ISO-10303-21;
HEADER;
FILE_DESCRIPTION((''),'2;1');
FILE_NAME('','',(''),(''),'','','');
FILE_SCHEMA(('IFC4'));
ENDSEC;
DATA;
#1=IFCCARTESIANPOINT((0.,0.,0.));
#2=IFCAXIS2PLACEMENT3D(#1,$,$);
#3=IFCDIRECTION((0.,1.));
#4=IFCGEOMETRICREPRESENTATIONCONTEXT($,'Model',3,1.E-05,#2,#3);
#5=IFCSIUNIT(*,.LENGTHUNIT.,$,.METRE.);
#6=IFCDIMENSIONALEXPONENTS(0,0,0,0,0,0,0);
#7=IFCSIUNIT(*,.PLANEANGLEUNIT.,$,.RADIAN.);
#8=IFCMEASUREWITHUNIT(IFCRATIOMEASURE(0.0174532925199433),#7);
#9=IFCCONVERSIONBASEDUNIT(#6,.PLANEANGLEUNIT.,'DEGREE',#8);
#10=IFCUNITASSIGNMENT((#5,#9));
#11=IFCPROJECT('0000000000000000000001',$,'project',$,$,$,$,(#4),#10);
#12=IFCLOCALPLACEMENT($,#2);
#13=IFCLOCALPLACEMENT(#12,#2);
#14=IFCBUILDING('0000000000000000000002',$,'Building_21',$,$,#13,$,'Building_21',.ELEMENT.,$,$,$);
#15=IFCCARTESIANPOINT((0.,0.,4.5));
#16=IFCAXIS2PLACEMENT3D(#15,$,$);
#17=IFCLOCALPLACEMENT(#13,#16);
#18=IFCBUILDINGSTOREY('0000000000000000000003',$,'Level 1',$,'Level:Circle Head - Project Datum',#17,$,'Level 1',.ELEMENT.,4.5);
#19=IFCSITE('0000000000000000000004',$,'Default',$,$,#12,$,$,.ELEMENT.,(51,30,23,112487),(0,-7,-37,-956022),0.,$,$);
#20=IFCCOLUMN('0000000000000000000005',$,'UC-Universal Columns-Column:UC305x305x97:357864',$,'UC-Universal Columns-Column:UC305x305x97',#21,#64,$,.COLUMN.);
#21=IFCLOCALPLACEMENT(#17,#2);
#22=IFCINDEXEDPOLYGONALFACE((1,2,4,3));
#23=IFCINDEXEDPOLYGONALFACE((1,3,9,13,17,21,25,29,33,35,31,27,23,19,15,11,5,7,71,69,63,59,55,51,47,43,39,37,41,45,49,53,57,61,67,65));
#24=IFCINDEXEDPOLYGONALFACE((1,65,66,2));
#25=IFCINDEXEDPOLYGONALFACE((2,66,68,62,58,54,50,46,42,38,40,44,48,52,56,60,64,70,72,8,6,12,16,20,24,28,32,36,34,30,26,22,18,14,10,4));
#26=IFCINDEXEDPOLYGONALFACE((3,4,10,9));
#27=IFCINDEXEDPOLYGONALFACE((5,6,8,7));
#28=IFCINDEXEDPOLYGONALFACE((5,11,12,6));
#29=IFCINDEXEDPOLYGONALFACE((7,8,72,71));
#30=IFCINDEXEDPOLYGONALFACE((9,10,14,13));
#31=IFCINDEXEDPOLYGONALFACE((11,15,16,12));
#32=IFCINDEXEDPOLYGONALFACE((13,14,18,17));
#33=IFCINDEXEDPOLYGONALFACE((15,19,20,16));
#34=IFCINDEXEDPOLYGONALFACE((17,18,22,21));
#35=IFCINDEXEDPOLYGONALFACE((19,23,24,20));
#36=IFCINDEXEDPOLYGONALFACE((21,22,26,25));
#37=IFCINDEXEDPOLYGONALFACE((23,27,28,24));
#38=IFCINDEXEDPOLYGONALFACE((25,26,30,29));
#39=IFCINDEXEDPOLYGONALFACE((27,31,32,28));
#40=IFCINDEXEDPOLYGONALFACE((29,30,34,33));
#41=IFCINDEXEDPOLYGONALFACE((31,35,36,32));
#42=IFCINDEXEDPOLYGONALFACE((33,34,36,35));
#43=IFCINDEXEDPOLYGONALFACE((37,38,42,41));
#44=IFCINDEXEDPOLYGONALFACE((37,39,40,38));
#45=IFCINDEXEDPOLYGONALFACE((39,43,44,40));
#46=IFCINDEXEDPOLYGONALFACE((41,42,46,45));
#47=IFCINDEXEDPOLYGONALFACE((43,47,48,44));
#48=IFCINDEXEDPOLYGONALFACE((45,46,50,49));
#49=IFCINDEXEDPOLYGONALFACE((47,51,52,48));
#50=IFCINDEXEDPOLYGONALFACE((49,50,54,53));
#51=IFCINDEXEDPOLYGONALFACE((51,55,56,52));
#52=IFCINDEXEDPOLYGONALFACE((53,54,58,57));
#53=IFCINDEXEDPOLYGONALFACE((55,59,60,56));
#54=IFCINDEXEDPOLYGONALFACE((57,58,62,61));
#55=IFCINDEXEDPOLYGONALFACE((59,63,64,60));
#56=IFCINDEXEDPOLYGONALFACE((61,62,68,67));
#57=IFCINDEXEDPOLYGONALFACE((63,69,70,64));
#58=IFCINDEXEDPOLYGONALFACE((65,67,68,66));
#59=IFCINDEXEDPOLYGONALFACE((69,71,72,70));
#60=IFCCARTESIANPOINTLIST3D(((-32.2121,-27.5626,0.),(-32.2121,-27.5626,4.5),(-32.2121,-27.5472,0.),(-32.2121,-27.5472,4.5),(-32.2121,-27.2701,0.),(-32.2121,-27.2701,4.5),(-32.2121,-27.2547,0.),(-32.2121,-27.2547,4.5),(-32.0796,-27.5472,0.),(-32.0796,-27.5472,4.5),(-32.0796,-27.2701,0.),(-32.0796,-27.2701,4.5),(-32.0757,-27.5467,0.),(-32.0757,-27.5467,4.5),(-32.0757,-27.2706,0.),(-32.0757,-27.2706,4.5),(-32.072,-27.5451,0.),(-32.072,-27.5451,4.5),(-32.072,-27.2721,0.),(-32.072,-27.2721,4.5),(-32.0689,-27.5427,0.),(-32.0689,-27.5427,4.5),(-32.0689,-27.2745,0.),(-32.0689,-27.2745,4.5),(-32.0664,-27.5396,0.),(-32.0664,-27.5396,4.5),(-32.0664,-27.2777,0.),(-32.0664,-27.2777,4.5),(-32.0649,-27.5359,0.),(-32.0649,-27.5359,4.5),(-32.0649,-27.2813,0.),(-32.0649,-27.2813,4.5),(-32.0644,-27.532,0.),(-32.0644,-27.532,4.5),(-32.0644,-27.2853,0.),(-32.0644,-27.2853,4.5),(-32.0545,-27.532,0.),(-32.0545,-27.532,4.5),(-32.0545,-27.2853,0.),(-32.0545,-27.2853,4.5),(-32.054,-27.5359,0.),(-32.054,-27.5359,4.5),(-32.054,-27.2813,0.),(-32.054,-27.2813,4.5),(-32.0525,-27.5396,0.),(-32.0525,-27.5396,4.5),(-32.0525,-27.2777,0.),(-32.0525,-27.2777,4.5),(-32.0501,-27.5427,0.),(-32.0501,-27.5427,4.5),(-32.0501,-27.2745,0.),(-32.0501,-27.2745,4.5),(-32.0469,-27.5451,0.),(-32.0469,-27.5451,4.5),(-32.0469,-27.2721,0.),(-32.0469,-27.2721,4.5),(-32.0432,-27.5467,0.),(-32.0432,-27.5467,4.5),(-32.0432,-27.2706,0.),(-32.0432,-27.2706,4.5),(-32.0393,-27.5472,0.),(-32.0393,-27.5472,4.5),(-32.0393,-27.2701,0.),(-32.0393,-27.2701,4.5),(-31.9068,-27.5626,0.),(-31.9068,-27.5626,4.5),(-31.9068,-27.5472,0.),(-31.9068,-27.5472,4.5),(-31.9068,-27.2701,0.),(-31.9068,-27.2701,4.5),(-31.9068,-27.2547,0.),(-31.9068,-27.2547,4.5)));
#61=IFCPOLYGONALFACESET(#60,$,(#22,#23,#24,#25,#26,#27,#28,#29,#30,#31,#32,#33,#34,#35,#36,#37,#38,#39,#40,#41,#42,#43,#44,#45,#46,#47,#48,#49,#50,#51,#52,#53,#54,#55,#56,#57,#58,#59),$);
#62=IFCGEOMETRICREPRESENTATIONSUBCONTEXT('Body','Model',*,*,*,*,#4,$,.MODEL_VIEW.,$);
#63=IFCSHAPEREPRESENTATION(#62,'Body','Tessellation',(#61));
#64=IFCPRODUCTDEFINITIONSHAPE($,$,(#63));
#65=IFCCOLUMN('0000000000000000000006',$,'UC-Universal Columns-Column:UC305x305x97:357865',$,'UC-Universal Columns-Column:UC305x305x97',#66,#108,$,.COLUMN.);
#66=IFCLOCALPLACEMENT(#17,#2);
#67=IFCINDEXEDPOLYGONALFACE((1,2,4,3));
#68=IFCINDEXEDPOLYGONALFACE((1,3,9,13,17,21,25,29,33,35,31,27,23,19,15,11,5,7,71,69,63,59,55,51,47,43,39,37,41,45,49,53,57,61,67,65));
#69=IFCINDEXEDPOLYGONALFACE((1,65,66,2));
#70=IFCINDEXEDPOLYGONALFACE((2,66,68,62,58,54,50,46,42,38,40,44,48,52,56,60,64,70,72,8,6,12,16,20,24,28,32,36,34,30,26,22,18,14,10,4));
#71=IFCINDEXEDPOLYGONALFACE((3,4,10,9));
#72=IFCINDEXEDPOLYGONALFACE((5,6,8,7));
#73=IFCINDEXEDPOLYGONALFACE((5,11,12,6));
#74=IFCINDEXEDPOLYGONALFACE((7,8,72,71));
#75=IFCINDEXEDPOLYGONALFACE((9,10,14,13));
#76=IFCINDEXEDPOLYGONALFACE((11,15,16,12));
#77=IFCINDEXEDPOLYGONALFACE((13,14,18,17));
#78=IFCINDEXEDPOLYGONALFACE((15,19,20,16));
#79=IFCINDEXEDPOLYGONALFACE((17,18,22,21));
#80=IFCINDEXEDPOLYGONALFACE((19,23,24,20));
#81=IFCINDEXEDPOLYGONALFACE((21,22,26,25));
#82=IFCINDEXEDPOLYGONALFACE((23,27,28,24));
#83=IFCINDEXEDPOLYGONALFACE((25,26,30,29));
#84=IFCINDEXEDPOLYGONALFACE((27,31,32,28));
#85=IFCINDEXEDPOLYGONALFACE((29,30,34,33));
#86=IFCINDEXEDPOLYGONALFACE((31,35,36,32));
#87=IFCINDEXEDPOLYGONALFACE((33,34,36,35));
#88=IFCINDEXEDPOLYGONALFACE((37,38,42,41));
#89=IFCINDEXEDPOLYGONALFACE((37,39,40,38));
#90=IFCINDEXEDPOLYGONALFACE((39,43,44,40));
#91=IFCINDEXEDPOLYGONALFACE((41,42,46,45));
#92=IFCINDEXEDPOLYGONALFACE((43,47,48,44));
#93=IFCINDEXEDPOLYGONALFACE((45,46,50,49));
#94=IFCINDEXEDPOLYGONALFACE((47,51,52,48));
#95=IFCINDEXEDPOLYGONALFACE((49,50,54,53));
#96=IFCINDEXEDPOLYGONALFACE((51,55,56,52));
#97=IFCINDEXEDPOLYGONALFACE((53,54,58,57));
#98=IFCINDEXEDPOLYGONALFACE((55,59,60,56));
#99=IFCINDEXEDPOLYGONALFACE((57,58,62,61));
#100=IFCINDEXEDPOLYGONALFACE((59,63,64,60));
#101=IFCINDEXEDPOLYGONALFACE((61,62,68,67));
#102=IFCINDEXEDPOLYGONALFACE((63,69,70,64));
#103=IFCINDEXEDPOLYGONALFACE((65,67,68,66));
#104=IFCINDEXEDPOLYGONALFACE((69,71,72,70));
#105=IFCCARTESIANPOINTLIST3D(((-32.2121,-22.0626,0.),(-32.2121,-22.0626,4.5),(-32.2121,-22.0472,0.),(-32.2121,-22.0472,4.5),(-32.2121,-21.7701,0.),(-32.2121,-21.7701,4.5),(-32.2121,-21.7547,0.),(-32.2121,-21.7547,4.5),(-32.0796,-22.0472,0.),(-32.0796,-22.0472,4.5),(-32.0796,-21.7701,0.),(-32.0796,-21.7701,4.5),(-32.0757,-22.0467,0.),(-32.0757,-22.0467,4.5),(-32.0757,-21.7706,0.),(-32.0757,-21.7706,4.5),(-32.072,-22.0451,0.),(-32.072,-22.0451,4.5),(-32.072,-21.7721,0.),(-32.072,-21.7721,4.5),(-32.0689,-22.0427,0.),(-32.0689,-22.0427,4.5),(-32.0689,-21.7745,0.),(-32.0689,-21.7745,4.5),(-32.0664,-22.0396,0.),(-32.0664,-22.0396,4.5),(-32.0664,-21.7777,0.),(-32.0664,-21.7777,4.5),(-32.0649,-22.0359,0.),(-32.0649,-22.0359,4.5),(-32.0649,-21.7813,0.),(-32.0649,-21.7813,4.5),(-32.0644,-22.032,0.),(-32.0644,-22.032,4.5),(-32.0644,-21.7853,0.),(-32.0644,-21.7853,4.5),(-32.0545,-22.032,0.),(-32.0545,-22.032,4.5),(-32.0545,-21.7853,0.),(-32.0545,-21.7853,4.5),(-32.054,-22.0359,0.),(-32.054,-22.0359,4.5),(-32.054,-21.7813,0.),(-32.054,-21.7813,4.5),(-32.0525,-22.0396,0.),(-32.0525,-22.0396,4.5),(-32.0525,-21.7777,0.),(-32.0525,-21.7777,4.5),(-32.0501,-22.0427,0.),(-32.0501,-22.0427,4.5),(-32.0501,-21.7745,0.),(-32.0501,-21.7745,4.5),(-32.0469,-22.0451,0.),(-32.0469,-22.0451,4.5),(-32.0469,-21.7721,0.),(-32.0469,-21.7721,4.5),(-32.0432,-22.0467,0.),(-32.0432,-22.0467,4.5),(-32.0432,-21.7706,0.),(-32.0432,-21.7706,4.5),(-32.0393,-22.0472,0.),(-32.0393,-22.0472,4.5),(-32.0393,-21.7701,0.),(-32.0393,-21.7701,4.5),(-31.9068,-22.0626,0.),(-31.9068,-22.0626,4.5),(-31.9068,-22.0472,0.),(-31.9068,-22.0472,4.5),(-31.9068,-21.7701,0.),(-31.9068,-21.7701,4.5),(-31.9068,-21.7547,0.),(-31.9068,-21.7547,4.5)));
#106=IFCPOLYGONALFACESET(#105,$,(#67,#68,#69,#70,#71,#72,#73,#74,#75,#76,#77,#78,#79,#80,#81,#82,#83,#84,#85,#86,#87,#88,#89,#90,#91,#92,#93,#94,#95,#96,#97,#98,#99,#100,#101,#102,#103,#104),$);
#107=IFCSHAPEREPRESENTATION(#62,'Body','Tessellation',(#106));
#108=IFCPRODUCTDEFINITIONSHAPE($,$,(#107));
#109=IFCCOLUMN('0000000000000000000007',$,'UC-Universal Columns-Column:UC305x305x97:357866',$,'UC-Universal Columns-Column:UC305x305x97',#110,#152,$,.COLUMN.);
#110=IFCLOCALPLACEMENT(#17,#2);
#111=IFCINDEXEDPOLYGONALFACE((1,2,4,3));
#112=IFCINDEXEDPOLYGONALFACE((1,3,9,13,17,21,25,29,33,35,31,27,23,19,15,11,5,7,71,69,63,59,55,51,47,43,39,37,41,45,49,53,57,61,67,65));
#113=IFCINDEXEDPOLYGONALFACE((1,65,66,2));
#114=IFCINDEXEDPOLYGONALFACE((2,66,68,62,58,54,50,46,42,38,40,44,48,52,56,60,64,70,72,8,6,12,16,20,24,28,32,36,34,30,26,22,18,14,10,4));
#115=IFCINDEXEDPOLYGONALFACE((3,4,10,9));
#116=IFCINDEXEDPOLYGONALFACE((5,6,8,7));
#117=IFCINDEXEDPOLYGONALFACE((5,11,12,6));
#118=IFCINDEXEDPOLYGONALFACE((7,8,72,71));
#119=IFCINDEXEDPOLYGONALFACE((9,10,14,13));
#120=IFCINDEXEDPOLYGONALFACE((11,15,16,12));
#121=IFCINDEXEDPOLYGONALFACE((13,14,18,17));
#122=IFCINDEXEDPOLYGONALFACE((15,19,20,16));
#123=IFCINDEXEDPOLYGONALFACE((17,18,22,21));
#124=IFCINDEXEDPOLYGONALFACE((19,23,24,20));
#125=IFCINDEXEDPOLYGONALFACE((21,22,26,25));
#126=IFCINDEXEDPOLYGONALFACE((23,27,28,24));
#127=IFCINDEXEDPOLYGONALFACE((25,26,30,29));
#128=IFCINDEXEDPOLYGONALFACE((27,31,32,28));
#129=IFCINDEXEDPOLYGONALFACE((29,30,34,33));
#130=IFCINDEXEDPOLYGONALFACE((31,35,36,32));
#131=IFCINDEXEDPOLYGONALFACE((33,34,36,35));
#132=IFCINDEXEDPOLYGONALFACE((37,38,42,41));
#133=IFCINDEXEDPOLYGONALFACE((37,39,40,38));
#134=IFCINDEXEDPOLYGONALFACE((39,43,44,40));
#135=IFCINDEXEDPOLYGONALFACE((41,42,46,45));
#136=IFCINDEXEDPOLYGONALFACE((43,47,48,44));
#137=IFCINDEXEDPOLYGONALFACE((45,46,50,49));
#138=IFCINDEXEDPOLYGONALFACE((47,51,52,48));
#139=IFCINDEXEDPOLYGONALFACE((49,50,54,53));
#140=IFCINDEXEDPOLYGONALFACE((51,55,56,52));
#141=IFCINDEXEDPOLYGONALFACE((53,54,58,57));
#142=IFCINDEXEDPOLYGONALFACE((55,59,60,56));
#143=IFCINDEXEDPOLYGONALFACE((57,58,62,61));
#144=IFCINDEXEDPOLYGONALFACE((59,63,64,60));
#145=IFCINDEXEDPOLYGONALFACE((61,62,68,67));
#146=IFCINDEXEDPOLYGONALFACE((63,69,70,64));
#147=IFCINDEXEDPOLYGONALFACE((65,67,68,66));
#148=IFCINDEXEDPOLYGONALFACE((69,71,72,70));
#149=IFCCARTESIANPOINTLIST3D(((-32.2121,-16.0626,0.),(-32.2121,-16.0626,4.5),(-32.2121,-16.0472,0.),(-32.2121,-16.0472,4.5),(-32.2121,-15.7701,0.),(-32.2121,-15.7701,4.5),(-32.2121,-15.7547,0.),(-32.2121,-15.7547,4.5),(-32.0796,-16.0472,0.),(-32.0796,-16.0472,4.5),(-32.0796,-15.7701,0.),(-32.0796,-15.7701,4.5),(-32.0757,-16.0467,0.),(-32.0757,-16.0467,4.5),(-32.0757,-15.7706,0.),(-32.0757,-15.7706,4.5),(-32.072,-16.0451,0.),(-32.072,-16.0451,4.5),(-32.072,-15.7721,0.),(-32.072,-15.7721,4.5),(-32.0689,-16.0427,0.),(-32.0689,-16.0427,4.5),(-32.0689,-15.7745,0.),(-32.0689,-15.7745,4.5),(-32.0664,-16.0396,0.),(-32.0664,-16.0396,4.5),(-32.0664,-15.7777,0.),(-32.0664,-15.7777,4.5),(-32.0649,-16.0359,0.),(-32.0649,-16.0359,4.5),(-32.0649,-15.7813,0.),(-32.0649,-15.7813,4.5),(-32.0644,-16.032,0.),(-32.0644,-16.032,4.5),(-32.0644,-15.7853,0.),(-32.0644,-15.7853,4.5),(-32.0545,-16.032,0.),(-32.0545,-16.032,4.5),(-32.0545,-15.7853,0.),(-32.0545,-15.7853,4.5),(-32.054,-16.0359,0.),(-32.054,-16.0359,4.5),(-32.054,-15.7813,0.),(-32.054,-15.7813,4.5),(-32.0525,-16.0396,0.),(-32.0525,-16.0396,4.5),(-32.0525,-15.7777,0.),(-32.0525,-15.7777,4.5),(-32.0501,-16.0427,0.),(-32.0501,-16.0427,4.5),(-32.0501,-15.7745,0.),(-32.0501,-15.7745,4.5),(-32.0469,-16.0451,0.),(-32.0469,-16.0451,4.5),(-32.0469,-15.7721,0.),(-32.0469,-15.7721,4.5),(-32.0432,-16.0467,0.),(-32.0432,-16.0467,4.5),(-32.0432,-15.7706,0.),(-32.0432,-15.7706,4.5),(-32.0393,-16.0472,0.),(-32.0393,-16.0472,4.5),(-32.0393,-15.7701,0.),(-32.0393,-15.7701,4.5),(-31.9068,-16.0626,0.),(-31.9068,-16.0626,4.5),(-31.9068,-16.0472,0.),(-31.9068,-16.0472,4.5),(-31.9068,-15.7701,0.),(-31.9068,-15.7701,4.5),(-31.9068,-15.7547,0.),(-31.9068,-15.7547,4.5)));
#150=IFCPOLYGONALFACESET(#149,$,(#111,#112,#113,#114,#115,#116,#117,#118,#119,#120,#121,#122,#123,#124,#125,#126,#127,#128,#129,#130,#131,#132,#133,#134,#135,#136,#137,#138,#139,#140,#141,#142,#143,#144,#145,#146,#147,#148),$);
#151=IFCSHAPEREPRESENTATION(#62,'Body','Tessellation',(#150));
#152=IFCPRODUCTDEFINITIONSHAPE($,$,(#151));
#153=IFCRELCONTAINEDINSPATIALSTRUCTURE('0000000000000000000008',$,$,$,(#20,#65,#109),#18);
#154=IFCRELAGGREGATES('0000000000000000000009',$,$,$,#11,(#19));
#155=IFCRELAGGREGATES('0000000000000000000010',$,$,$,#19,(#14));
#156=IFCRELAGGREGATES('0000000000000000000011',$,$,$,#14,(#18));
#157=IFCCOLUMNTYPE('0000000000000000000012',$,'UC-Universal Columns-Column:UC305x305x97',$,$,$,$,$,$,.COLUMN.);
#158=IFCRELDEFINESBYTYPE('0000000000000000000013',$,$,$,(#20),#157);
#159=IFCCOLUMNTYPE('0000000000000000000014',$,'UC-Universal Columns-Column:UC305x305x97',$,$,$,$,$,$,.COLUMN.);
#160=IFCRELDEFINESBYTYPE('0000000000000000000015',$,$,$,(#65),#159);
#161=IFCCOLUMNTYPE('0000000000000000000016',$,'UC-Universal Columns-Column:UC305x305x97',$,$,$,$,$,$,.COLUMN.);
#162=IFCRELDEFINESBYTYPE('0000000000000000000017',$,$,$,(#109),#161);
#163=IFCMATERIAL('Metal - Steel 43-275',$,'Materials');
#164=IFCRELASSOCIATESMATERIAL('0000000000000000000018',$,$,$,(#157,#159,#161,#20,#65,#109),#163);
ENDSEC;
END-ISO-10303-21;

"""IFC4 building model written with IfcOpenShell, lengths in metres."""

from ifc_helpers import new_model, entity, si_unit, converted_unit, direction, frame, frame_2d, origin, place, context, subcontext, project, spatial, polyline, circle_curve, parameter, trimmed, segment, composite_curve, i_section, outline, extrude, source, transform, mapped, material, material_profile, profile_set, profile_usage, type_object, type_shapes, element, save


model = new_model("IFC4")

# Units and contexts
model_context = context("Model", 3, precision=1e-05, world=origin(), true_north=direction((0.0, 1.0)))
body_context = subcontext(model_context, "Body", "Model", "MODEL_VIEW")
ifc_project = project(units=[si_unit("LENGTHUNIT", "METRE"), converted_unit("PLANEANGLEUNIT", "DEGREE", entity("IfcRatioMeasure", 0.0174532925199433), si_unit("PLANEANGLEUNIT", "RADIAN"), dimensions=[0, 0, 0, 0, 0, 0, 0])], contexts=[model_context])

# Site, building, storey
site_placement = place(None, origin())
site = spatial("IfcSite", under=ifc_project, at=site_placement, Name="Default", CompositionType="ELEMENT", RefLatitude=(51, 30, 23, 112487), RefLongitude=(0, -7, -37, -956022), RefElevation=0.0)
building_placement = place(site_placement, origin())
building = spatial("IfcBuilding", under=site, at=building_placement, Name="Building_21", LongName="Building_21", CompositionType="ELEMENT")
storey_placement = place(building_placement, frame((0.0, 0.0, 4.5)))
storey = spatial("IfcBuildingStorey", under=building, at=storey_placement, Name="Level 1", ObjectType="Level:Circle Head - Project Datum", LongName="Level 1", CompositionType="ELEMENT", Elevation=4.5)

# Columns
ifc_material_1 = material(Name="Metal - Steel 43-275", Category="Materials")
ifc_material_profile_1 = material_profile(ifc_material_1, outline(composite_curve([segment(polyline([(-0.1527, 0.154, 0.0), (0.1527, 0.154, 0.0)]), True, "CONTINUOUS"), segment(polyline([(0.1527, 0.154, 0.0), (0.1527, 0.1386, 0.0)]), True, "CONTINUOUS"), segment(polyline([(0.1527, 0.1386, 0.0), (0.0201, 0.1386, 0.0)]), True, "CONTINUOUS"), segment(trimmed(circle_curve(frame((0.0201, 0.1234, 0.0)), 0.0152), [parameter(90.0)], [parameter(180.0)], True, "PARAMETER"), True, "CONTINUOUS"), segment(polyline([(0.0049, 0.1234, 0.0), (0.0049, -0.1234, 0.0)]), True, "CONTINUOUS"), segment(trimmed(circle_curve(frame((0.0201, -0.1234, 0.0)), 0.0152), [parameter(180.0)], [parameter(270.0)], True, "PARAMETER"), True, "CONTINUOUS"), segment(polyline([(0.0201, -0.1386, 0.0), (0.1527, -0.1386, 0.0)]), True, "CONTINUOUS"), segment(polyline([(0.1527, -0.1386, 0.0), (0.1527, -0.154, 0.0)]), True, "CONTINUOUS"), segment(polyline([(0.1527, -0.154, 0.0), (-0.1527, -0.154, 0.0)]), True, "CONTINUOUS"), segment(polyline([(-0.1527, -0.154, 0.0), (-0.1527, -0.1386, 0.0)]), True, "CONTINUOUS"), segment(polyline([(-0.1527, -0.1386, 0.0), (-0.0201, -0.1386, 0.0)]), True, "CONTINUOUS"), segment(trimmed(circle_curve(frame((-0.0201, -0.1234, 0.0)), 0.0152), [parameter(270.0)], [parameter(0.0)], True, "PARAMETER"), True, "CONTINUOUS"), segment(polyline([(-0.0049, -0.1234, 0.0), (-0.005, 0.1234, 0.0)]), True, "CONTINUOUS"), segment(trimmed(circle_curve(frame((-0.0201, 0.1234, 0.0)), 0.0152), [parameter(0.0)], [parameter(90.0)], True, "PARAMETER"), True, "CONTINUOUS"), segment(polyline([(-0.0201, 0.1386, 0.0), (-0.1527, 0.1386, 0.0)]), True, "CONTINUOUS"), segment(polyline([(-0.1527, 0.1386, 0.0), (-0.1527, 0.154, 0.0)]), True, "CONTINUOUS")], self_intersect=False), kind="CURVE"), Name="UC305x305x97")
ifc_material_profile_2 = material_profile(ifc_material_1, outline(composite_curve([segment(polyline([(0.1527, 0.154, 0.0), (0.1527, 0.1386, 0.0)]), True, "CONTINUOUS"), segment(polyline([(0.1527, 0.1386, 0.0), (0.0049, 0.1386, 0.0)]), True, "CONTINUOUS"), segment(polyline([(0.0049, 0.1386, 0.0), (0.0049, -0.1386, 0.0)]), True, "CONTINUOUS"), segment(polyline([(0.0049, -0.1386, 0.0), (0.1527, -0.1386, 0.0)]), True, "CONTINUOUS"), segment(polyline([(0.1527, -0.1386, 0.0), (0.1527, -0.154, 0.0)]), True, "CONTINUOUS"), segment(polyline([(0.1527, -0.154, 0.0), (-0.1527, -0.154, 0.0)]), True, "CONTINUOUS"), segment(polyline([(-0.1527, -0.154, 0.0), (-0.1527, -0.1386, 0.0)]), True, "CONTINUOUS"), segment(polyline([(-0.1527, -0.1386, 0.0), (-0.005, -0.1386, 0.0)]), True, "CONTINUOUS"), segment(polyline([(-0.005, -0.1386, 0.0), (-0.005, 0.1386, 0.0)]), True, "CONTINUOUS"), segment(polyline([(-0.005, 0.1386, 0.0), (-0.1527, 0.1386, 0.0)]), True, "CONTINUOUS"), segment(polyline([(-0.1527, 0.1386, 0.0), (-0.1527, 0.154, 0.0)]), True, "CONTINUOUS"), segment(polyline([(-0.1527, 0.154, 0.0), (0.1527, 0.154, 0.0)]), True, "CONTINUOUS")], self_intersect=False), kind="CURVE"), Name="UC305x305x97")
ifc_profile_set_1 = profile_set([ifc_material_profile_1, ifc_material_profile_2], Name="UC305x305x97")
ifc_profile_usage_1 = profile_usage(ifc_profile_set_1)
column_type_1 = type_object("IfcColumnType", Name="UC-Universal Columns-Column:UC305x305x97", PredefinedType="COLUMN", material=ifc_profile_set_1)
shared_shape_1 = source(origin(), body_context, "Body", "SweptSolid", [
    extrude(i_section(OverallWidth=0.3053, OverallDepth=0.3079, WebThickness=0.0099, FlangeThickness=0.0154, FilletRadius=0.0152, at=frame_2d((0.0, 0.0), x_axis=(0.0, 1.0))), frame((-32.0595, -27.4086, 4.5), z_axis=(0.0, 0.0, 1.0), x_axis=(0.0, -1.0, 0.0)), (0.0, 0.0, 1.0), 4.5),
])
type_shapes(column_type_1, [shared_shape_1])
column_1_placement = place(storey_placement, frame((0.0, 0.0, -4.5)))
element("IfcColumn", 1, at=column_1_placement, inside=storey, type_object=column_type_1, material=ifc_profile_usage_1, Name="UC-Universal Columns-Column:UC305x305x97:357864", ObjectType="UC-Universal Columns-Column:UC305x305x97", PredefinedType="COLUMN", context=body_context, shape_type="MappedRepresentation", body=[
    mapped(shared_shape_1, transform((0.0, 0.0, 0.0), scale=1.0)),
])
ifc_profile_usage_2 = profile_usage(ifc_profile_set_1)
column_type_2 = type_object("IfcColumnType", Name="UC-Universal Columns-Column:UC305x305x97", PredefinedType="COLUMN", material=ifc_profile_set_1)
shared_shape_2 = source(origin(), body_context, "Body", "SweptSolid", [
    extrude(i_section(OverallWidth=0.3053, OverallDepth=0.3079, WebThickness=0.0099, FlangeThickness=0.0154, FilletRadius=0.0152, at=frame_2d((0.0, 0.0), x_axis=(0.0, 1.0))), frame((-32.0595, -21.9086, 4.5), z_axis=(0.0, 0.0, 1.0), x_axis=(0.0, -1.0, 0.0)), (0.0, 0.0, 1.0), 4.5),
])
type_shapes(column_type_2, [shared_shape_2])
column_2_placement = place(storey_placement, frame((0.0, 0.0, -4.5)))
element("IfcColumn", 2, at=column_2_placement, inside=storey, type_object=column_type_2, material=ifc_profile_usage_2, Name="UC-Universal Columns-Column:UC305x305x97:357865", ObjectType="UC-Universal Columns-Column:UC305x305x97", PredefinedType="COLUMN", context=body_context, shape_type="MappedRepresentation", body=[
    mapped(shared_shape_2, transform((0.0, 0.0, 0.0), scale=1.0)),
])
ifc_profile_usage_3 = profile_usage(ifc_profile_set_1)
column_type_3 = type_object("IfcColumnType", Name="UC-Universal Columns-Column:UC305x305x97", PredefinedType="COLUMN", material=ifc_profile_set_1)
shared_shape_3 = source(origin(), body_context, "Body", "SweptSolid", [
    extrude(i_section(OverallWidth=0.3053, OverallDepth=0.3079, WebThickness=0.0099, FlangeThickness=0.0154, FilletRadius=0.0152, at=frame_2d((0.0, 0.0), x_axis=(0.0, 1.0))), frame((-32.0595, -15.9086, 4.5), z_axis=(0.0, 0.0, 1.0), x_axis=(0.0, -1.0, 0.0)), (0.0, 0.0, 1.0), 4.5),
])
type_shapes(column_type_3, [shared_shape_3])
column_3_placement = place(storey_placement, frame((0.0, 0.0, -4.5)))
element("IfcColumn", 3, at=column_3_placement, inside=storey, type_object=column_type_3, material=ifc_profile_usage_3, Name="UC-Universal Columns-Column:UC305x305x97:357866", ObjectType="UC-Universal Columns-Column:UC305x305x97", PredefinedType="COLUMN", context=body_context, shape_type="MappedRepresentation", body=[
    mapped(shared_shape_3, transform((0.0, 0.0, 0.0), scale=1.0)),
])

save(model, "model.ifc")
